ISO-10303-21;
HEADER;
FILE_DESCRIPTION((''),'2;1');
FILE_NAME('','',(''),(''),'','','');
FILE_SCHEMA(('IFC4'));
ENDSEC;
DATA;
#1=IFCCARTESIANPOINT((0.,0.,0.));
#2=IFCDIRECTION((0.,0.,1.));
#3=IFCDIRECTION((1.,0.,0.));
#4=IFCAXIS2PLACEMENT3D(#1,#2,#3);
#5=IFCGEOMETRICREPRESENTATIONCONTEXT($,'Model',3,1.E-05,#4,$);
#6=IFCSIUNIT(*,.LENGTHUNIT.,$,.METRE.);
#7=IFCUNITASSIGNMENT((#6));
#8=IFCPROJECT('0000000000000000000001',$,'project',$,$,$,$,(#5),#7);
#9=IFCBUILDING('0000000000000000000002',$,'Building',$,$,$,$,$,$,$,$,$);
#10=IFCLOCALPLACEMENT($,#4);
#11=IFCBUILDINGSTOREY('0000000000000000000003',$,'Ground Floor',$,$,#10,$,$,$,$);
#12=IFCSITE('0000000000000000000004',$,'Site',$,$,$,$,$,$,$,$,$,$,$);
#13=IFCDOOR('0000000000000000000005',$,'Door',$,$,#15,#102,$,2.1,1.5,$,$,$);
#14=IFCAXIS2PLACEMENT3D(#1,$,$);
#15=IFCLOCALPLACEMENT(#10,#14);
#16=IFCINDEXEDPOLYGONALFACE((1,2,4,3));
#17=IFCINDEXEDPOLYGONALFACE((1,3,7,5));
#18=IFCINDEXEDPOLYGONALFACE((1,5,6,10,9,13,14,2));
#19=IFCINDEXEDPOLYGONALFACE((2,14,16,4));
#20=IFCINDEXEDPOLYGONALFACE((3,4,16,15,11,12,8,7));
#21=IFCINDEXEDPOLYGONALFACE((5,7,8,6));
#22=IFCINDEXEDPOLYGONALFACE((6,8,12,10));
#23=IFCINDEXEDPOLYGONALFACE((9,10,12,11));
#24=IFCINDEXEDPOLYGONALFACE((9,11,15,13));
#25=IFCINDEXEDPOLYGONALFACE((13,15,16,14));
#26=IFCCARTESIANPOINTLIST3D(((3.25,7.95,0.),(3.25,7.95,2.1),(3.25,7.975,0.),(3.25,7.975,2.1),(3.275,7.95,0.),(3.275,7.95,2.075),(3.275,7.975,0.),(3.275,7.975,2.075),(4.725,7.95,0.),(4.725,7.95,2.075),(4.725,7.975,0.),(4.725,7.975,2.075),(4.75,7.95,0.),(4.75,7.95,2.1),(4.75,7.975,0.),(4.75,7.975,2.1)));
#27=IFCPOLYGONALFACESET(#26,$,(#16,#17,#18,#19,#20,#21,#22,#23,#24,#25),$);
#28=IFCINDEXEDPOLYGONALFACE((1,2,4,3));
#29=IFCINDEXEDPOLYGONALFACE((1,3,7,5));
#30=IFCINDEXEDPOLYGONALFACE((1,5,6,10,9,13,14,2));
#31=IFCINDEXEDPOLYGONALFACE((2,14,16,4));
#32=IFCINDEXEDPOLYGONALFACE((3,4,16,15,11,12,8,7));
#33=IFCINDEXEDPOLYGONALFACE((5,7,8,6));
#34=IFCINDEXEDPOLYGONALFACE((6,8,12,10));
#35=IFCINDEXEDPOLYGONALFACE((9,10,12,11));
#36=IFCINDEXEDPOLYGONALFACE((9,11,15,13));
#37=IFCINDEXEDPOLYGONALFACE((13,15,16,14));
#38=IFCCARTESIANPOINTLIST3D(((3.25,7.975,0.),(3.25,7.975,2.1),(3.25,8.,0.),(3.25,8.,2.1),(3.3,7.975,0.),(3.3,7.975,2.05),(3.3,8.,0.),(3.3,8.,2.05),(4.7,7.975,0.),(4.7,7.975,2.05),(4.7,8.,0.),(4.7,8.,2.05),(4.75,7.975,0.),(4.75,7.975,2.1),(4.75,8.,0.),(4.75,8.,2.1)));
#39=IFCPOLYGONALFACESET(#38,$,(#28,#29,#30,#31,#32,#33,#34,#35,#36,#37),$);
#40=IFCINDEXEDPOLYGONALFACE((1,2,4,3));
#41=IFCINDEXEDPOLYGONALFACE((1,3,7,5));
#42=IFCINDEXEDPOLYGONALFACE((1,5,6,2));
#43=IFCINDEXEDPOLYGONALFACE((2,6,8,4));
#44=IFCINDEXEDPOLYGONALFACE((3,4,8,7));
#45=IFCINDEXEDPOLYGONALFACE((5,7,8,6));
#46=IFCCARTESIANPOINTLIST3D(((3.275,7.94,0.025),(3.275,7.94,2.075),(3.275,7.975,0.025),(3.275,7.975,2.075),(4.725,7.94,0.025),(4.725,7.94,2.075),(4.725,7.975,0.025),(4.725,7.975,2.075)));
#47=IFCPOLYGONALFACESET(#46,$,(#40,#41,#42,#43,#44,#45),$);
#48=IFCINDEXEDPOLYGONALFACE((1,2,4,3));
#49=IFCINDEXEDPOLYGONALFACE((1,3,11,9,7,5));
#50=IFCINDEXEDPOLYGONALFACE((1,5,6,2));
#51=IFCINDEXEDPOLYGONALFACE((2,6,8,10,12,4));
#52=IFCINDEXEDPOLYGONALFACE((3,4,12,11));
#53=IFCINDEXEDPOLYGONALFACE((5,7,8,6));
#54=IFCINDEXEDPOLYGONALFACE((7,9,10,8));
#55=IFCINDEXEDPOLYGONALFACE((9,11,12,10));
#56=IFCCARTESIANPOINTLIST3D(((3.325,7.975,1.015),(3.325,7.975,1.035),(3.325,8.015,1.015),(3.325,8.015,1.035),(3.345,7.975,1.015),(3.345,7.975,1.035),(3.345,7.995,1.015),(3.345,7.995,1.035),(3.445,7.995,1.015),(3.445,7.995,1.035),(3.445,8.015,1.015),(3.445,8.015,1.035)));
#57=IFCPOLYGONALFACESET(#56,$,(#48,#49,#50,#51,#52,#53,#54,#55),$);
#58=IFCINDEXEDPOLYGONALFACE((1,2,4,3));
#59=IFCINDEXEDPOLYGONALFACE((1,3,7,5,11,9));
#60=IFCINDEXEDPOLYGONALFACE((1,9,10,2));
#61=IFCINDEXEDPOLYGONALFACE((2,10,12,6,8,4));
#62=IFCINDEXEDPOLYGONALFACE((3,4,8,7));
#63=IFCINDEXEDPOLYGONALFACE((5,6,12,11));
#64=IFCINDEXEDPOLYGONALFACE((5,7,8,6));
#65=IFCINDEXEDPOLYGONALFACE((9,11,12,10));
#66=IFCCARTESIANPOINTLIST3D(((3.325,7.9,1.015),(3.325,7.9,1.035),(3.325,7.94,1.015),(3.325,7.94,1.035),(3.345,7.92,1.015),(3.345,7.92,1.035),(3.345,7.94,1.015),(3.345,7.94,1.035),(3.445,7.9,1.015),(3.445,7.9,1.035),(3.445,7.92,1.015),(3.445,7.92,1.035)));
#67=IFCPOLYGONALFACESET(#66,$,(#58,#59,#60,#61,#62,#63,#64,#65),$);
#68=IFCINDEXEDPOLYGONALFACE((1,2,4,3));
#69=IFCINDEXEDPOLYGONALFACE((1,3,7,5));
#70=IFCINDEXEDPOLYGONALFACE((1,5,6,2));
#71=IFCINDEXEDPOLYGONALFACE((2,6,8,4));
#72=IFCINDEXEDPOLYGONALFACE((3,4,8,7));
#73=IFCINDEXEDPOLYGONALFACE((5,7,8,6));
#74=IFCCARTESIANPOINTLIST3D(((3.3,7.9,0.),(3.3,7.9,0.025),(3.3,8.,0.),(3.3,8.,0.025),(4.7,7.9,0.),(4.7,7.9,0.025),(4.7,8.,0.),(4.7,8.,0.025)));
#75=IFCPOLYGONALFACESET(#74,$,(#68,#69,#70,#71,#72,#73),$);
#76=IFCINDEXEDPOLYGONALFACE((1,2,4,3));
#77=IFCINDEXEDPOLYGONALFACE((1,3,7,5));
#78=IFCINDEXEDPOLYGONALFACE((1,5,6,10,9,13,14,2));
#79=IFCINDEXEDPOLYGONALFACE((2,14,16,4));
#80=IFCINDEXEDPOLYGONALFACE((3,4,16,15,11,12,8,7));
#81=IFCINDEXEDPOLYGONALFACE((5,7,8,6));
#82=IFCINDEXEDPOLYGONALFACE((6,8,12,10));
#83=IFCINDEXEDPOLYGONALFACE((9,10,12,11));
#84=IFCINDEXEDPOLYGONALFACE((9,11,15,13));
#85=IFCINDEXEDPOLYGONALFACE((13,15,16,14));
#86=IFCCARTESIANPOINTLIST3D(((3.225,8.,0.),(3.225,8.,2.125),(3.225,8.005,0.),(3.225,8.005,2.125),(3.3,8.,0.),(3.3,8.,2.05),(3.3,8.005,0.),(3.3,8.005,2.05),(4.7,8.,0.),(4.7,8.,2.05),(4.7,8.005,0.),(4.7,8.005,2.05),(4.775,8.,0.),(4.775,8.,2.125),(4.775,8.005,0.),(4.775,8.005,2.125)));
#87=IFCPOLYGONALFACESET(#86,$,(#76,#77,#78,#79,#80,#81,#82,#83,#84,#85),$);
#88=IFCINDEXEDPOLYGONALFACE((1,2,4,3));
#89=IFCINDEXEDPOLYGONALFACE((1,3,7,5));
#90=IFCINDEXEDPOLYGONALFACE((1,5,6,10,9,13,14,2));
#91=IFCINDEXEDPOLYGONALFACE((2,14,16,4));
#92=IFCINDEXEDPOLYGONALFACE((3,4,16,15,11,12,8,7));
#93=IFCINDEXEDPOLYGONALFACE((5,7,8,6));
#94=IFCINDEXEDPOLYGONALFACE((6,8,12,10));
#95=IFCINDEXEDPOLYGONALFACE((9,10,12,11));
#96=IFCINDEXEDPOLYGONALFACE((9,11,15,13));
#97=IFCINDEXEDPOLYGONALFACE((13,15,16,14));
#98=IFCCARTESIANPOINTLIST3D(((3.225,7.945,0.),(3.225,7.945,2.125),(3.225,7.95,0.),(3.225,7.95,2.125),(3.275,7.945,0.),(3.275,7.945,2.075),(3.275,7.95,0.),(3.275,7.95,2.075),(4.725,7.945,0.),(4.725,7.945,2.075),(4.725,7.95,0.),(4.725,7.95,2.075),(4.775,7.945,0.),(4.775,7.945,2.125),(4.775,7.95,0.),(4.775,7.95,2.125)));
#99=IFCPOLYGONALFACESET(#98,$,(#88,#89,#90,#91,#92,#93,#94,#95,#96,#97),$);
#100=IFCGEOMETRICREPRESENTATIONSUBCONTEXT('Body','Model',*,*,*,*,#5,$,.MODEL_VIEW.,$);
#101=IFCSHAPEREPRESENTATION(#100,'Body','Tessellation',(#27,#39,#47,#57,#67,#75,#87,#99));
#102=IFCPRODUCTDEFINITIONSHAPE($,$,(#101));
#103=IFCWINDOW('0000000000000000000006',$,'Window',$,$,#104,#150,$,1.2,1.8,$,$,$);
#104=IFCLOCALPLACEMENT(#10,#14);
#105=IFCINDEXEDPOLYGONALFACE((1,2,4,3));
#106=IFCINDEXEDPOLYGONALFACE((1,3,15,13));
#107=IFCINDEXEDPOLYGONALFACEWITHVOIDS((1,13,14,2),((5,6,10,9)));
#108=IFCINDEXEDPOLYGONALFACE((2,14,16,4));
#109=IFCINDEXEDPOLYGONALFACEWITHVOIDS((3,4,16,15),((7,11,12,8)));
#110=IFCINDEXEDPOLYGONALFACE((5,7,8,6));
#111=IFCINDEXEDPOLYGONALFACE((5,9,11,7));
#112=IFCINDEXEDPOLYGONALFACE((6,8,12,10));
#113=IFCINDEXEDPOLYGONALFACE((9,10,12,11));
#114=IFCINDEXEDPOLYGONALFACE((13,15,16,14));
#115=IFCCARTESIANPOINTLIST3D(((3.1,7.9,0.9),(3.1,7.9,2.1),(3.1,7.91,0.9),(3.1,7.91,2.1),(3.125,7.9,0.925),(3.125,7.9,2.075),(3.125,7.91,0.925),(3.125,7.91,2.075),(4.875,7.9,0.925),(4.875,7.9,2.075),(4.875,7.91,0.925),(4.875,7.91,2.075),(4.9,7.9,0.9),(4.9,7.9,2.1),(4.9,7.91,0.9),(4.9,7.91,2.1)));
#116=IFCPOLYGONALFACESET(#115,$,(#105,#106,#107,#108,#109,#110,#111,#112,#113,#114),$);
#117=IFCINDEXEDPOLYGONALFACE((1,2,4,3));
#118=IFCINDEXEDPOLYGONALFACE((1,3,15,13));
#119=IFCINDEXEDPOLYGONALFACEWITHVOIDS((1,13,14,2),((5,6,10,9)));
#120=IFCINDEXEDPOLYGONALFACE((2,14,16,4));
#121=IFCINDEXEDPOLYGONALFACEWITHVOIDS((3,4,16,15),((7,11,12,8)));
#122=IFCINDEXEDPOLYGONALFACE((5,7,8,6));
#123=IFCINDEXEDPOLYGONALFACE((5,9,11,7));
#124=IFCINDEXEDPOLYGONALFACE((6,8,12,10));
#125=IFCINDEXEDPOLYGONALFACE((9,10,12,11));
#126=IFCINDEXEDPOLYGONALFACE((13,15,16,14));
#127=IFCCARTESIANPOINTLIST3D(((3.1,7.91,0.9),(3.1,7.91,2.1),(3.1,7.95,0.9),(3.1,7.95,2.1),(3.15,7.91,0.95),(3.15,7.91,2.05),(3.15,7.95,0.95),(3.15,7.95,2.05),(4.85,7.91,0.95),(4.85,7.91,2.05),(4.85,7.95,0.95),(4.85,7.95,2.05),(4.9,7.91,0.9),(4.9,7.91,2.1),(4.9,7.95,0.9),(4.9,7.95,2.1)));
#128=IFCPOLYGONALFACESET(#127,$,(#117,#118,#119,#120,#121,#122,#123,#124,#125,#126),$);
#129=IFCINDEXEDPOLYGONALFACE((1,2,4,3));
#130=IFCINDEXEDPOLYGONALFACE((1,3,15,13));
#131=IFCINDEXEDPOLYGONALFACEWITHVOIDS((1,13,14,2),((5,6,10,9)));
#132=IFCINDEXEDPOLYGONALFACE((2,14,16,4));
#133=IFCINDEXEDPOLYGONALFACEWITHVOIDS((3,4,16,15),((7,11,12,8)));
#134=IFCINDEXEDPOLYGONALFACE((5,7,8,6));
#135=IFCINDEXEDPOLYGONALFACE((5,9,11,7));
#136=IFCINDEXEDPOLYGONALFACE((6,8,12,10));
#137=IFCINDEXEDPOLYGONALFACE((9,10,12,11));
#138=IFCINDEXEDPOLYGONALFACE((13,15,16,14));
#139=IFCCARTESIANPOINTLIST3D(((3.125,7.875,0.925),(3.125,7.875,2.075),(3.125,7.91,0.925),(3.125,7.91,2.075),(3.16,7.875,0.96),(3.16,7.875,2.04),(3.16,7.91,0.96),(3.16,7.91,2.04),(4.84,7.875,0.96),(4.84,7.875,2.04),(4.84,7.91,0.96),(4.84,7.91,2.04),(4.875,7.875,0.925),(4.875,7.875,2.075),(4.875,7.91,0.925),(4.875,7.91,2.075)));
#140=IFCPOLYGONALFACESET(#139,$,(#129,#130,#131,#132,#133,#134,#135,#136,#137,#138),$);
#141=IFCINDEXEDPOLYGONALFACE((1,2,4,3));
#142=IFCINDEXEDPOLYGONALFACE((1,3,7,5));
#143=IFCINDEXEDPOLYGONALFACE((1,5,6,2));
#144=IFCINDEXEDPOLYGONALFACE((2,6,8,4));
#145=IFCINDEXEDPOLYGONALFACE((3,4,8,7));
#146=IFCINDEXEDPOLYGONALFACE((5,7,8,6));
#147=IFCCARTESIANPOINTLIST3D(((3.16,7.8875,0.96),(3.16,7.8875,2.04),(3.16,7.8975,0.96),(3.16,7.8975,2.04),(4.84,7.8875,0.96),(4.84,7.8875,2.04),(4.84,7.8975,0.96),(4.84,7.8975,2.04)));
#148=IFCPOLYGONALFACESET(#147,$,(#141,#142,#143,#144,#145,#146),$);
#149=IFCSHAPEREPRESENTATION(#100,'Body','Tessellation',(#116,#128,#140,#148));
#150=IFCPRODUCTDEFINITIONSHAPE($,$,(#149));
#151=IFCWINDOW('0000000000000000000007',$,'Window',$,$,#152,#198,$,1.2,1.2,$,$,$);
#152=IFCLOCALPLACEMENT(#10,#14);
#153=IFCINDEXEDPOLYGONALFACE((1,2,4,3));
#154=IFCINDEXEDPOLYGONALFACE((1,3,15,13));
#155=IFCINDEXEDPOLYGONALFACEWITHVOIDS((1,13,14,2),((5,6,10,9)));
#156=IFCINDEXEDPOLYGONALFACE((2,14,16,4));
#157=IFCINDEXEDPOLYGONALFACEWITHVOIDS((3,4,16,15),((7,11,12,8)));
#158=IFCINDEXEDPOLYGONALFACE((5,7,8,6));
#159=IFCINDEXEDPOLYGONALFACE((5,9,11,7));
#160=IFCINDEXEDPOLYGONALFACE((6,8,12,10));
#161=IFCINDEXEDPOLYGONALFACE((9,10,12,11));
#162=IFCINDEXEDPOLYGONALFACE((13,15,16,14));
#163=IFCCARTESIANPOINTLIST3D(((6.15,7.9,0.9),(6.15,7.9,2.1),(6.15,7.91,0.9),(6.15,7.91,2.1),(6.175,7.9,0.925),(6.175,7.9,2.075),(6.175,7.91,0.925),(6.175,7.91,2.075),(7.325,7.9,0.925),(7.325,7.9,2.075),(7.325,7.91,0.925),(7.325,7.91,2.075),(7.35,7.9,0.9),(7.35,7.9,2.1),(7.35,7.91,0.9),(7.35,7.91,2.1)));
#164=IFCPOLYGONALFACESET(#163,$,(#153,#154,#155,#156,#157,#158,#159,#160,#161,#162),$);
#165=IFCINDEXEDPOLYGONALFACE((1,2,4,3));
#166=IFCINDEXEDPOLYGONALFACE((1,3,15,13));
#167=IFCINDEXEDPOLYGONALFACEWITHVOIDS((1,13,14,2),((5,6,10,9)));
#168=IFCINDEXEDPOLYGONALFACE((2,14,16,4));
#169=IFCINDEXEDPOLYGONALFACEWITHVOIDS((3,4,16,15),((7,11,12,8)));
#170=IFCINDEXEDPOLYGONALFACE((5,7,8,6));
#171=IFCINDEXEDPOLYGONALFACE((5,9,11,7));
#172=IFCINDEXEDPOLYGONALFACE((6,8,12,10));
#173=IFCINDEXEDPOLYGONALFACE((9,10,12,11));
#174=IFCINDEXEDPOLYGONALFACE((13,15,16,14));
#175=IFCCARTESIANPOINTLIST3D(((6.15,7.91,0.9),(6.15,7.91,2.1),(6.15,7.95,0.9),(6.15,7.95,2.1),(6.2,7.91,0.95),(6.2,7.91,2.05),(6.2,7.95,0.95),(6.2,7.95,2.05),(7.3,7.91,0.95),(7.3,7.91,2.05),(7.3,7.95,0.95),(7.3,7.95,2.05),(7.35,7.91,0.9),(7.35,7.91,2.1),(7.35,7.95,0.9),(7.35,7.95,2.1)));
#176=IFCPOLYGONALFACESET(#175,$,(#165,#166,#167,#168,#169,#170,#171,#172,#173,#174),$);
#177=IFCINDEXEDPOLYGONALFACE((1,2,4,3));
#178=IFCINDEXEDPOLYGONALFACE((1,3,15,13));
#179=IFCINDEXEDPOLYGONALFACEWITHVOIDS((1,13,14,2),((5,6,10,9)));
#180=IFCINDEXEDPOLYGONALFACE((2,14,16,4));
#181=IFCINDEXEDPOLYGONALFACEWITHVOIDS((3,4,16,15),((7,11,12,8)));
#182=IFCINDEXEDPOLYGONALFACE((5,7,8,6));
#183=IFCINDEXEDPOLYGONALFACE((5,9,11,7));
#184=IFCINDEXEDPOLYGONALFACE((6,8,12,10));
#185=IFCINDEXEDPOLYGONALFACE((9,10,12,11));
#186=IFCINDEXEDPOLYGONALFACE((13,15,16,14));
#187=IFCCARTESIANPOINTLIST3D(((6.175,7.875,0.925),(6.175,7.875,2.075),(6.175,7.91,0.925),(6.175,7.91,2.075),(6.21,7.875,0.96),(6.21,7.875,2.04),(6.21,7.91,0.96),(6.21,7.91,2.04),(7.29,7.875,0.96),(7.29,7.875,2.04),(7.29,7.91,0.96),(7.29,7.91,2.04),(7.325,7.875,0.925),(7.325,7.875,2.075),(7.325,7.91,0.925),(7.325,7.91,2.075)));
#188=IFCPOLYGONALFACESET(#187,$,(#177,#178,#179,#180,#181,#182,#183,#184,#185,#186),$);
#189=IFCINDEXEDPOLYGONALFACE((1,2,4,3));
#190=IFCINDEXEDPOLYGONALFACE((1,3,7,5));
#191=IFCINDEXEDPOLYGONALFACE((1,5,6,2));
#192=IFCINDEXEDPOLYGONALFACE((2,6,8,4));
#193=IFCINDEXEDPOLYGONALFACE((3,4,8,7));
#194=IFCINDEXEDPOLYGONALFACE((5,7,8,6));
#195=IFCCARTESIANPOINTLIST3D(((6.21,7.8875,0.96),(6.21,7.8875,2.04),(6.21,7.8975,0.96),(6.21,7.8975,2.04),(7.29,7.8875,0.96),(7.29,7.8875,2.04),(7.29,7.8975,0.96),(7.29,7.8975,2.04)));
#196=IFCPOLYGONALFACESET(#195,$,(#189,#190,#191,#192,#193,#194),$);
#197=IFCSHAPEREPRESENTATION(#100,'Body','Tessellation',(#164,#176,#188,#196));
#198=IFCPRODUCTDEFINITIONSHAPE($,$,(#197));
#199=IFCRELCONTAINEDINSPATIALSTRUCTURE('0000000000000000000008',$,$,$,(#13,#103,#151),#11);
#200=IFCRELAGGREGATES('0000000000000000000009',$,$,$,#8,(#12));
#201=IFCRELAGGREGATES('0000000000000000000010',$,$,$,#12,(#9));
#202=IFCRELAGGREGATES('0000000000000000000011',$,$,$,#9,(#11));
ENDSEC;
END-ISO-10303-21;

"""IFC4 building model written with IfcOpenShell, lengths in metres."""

from ifc_helpers import new_model, si_unit, frame, origin_with_axes, place, context, subcontext, project, spatial, line, indexed_curve, outline, extrude, element, save


model = new_model("IFC4")

# Units and contexts
model_context = context("Model", 3, precision=1e-05, world=origin_with_axes())
body_context = subcontext(model_context, "Body", "Model", "MODEL_VIEW")
ifc_project = project(units=[si_unit("LENGTHUNIT", "METRE")], contexts=[model_context])

# Site, building, storey
site = spatial("IfcSite", under=ifc_project, Name="Site")
building = spatial("IfcBuilding", under=site, Name="Building")
storey_placement = place(None, origin_with_axes())
storey = spatial("IfcBuildingStorey", under=building, at=storey_placement, Name="Ground Floor")

# Door
door_1_placement = place(storey_placement, frame((4.75, 8.0, 0.0), z_axis=(0.0, 0.0, 1.0), x_axis=(-1.0, 0.0, 0.0)))
element("IfcDoor", 1, at=door_1_placement, inside=storey, Name="Door", OverallHeight=2.1, OverallWidth=1.5, context=body_context, shape_type="SweptSolid", body=[
    extrude(outline(indexed_curve([(0.0, 0.0), (0.0, 2.1), (1.5, 2.1), (1.5, 0.0), (1.475, 0.0), (1.475, 2.075), (0.025, 2.075), (0.025, 0.0)], segments=[line(1, 2, 3, 4, 5, 6, 7, 8, 1)])), frame((0.0, 0.025, 0.0), z_axis=(0.0, -1.0, 0.0), x_axis=(1.0, 0.0, 0.0)), (0.0, 0.0, -1.0), 0.025),
    extrude(outline(indexed_curve([(0.0, 0.0), (0.0, 2.1), (1.5, 2.1), (1.5, 0.0), (1.45, 0.0), (1.45, 2.05), (0.05, 2.05), (0.05, 0.0)], segments=[line(1, 2, 3, 4, 5, 6, 7, 8, 1)])), frame((0.0, 0.0, 0.0), z_axis=(0.0, -1.0, 0.0), x_axis=(1.0, 0.0, 0.0)), (0.0, 0.0, -1.0), 0.025),
    extrude(outline(indexed_curve([(0.0, 0.0), (1.45, 0.0), (1.45, 0.035), (0.0, 0.035)], segments=[line(1, 2, 3, 4, 1)])), frame((0.025, 0.025, 0.025), z_axis=(0.0, 0.0, 1.0), x_axis=(1.0, 0.0, 0.0)), (0.0, 0.0, 1.0), 2.05),
    extrude(outline(indexed_curve([(0.0, 0.0), (0.0, -0.04), (-0.12, -0.04), (-0.12, -0.02), (-0.02, -0.02), (-0.02, 0.0)], segments=[line(1, 2, 3, 4, 5, 6, 1)])), frame((1.425, 0.025, 1.015), z_axis=(0.0, 0.0, 1.0), x_axis=(1.0, 0.0, 0.0)), (0.0, 0.0, 1.0), 0.02),
    extrude(outline(indexed_curve([(0.0, 0.0), (0.0, 0.04), (-0.12, 0.04), (-0.12, 0.02), (-0.02, 0.02), (-0.02, 0.0)], segments=[line(1, 2, 3, 4, 5, 6, 1)])), frame((1.425, 0.06, 1.015), z_axis=(0.0, 0.0, 1.0), x_axis=(1.0, 0.0, 0.0)), (0.0, 0.0, 1.0), 0.02),
    extrude(outline(indexed_curve([(0.0, 0.0), (1.4, 0.0), (1.4, 0.1), (0.0, 0.1)], segments=[line(1, 2, 3, 4, 1)])), frame((0.05, 0.0, 0.0), z_axis=(0.0, 0.0, 1.0), x_axis=(1.0, 0.0, 0.0)), (0.0, 0.0, 1.0), 0.025),
    extrude(outline(indexed_curve([(0.0, 0.0), (0.0, 2.125), (1.55, 2.125), (1.55, 0.0), (1.475, 0.0), (1.475, 2.05), (0.075, 2.05), (0.075, 0.0)], segments=[line(1, 2, 3, 4, 5, 6, 7, 8, 1)])), frame((-0.025, -0.005, 0.0), z_axis=(0.0, -1.0, 0.0), x_axis=(1.0, 0.0, 0.0)), (0.0, 0.0, -1.0), 0.005),
    extrude(outline(indexed_curve([(0.0, 0.0), (0.0, 2.125), (1.55, 2.125), (1.55, 0.0), (1.5, 0.0), (1.5, 2.075), (0.05, 2.075), (0.05, 0.0)], segments=[line(1, 2, 3, 4, 5, 6, 7, 8, 1)])), frame((-0.025, 0.05, 0.0), z_axis=(0.0, -1.0, 0.0), x_axis=(1.0, 0.0, 0.0)), (0.0, 0.0, -1.0), 0.005),
])

# Windows
window_1_placement = place(storey_placement, frame((4.9, 8.0, 0.9), z_axis=(0.0, 0.0, 1.0), x_axis=(-1.0, 0.0, 0.0)))
element("IfcWindow", 2, at=window_1_placement, inside=storey, Name="Window", OverallHeight=1.2, OverallWidth=1.8, context=body_context, shape_type="SweptSolid", body=[
    extrude(outline(indexed_curve([(0.0, 0.0), (1.8, 0.0), (1.8, 1.2), (0.0, 1.2)], segments=[line(1, 2, 3, 4, 1)]), holes=[indexed_curve([(0.025, 0.025), (1.775, 0.025), (1.775, 1.175), (0.025, 1.175)], segments=[line(1, 2, 3, 4, 1)])]), frame((0.0, 0.09, 0.0), z_axis=(0.0, -1.0, 0.0), x_axis=(1.0, 0.0, 0.0)), (0.0, 0.0, -1.0), 0.01),
    extrude(outline(indexed_curve([(0.0, 0.0), (1.8, 0.0), (1.8, 1.2), (0.0, 1.2)], segments=[line(1, 2, 3, 4, 1)]), holes=[indexed_curve([(0.05, 0.05), (1.75, 0.05), (1.75, 1.15), (0.05, 1.15)], segments=[line(1, 2, 3, 4, 1)])]), frame((0.0, 0.05, 0.0), z_axis=(0.0, -1.0, 0.0), x_axis=(1.0, 0.0, 0.0)), (0.0, 0.0, -1.0), 0.04),
    extrude(outline(indexed_curve([(0.0, 0.0), (1.75, 0.0), (1.75, 1.15), (0.0, 1.15)], segments=[line(1, 2, 3, 4, 1)]), holes=[indexed_curve([(0.035, 0.035), (1.715, 0.035), (1.715, 1.115), (0.035, 1.115)], segments=[line(1, 2, 3, 4, 1)])]), frame((0.025, 0.09, 0.025), z_axis=(0.0, -1.0, 0.0), x_axis=(1.0, 0.0, 0.0)), (0.0, 0.0, -1.0), 0.035),
    extrude(outline(indexed_curve([(0.035, 0.035), (1.715, 0.035), (1.715, 1.115), (0.035, 1.115)], segments=[line(1, 2, 3, 4, 1)])), frame((0.025, 0.1025, 0.025), z_axis=(0.0, -1.0, 0.0), x_axis=(1.0, 0.0, 0.0)), (0.0, 0.0, -1.0), 0.01),
])
for number, where, z_axis, x_axis, name in (
    (3, (7.35, 8.0, 0.9), (0.0, 0.0, 1.0), (-1.0, 0.0, 0.0), "Window"),
):
    element("IfcWindow", number, at=place(storey_placement, frame(where, z_axis=z_axis, x_axis=x_axis)), inside=storey, Name=name, OverallHeight=1.2, OverallWidth=1.2, context=body_context, shape_type="SweptSolid", body=[
        extrude(outline(indexed_curve([(0.0, 0.0), (1.2, 0.0), (1.2, 1.2), (0.0, 1.2)], segments=[line(1, 2, 3, 4, 1)]), holes=[indexed_curve([(0.025, 0.025), (1.175, 0.025), (1.175, 1.175), (0.025, 1.175)], segments=[line(1, 2, 3, 4, 1)])]), frame((0.0, 0.09, 0.0), z_axis=(0.0, -1.0, 0.0), x_axis=(1.0, 0.0, 0.0)), (0.0, 0.0, -1.0), 0.01),
        extrude(outline(indexed_curve([(0.0, 0.0), (1.2, 0.0), (1.2, 1.2), (0.0, 1.2)], segments=[line(1, 2, 3, 4, 1)]), holes=[indexed_curve([(0.05, 0.05), (1.15, 0.05), (1.15, 1.15), (0.05, 1.15)], segments=[line(1, 2, 3, 4, 1)])]), frame((0.0, 0.05, 0.0), z_axis=(0.0, -1.0, 0.0), x_axis=(1.0, 0.0, 0.0)), (0.0, 0.0, -1.0), 0.04),
        extrude(outline(indexed_curve([(0.0, 0.0), (1.15, 0.0), (1.15, 1.15), (0.0, 1.15)], segments=[line(1, 2, 3, 4, 1)]), holes=[indexed_curve([(0.035, 0.035), (1.115, 0.035), (1.115, 1.115), (0.035, 1.115)], segments=[line(1, 2, 3, 4, 1)])]), frame((0.025, 0.09, 0.025), z_axis=(0.0, -1.0, 0.0), x_axis=(1.0, 0.0, 0.0)), (0.0, 0.0, -1.0), 0.035),
        extrude(outline(indexed_curve([(0.035, 0.035), (1.115, 0.035), (1.115, 1.115), (0.035, 1.115)], segments=[line(1, 2, 3, 4, 1)])), frame((0.025, 0.1025, 0.025), z_axis=(0.0, -1.0, 0.0), x_axis=(1.0, 0.0, 0.0)), (0.0, 0.0, -1.0), 0.01),
    ])

save(model, "model.ifc")
